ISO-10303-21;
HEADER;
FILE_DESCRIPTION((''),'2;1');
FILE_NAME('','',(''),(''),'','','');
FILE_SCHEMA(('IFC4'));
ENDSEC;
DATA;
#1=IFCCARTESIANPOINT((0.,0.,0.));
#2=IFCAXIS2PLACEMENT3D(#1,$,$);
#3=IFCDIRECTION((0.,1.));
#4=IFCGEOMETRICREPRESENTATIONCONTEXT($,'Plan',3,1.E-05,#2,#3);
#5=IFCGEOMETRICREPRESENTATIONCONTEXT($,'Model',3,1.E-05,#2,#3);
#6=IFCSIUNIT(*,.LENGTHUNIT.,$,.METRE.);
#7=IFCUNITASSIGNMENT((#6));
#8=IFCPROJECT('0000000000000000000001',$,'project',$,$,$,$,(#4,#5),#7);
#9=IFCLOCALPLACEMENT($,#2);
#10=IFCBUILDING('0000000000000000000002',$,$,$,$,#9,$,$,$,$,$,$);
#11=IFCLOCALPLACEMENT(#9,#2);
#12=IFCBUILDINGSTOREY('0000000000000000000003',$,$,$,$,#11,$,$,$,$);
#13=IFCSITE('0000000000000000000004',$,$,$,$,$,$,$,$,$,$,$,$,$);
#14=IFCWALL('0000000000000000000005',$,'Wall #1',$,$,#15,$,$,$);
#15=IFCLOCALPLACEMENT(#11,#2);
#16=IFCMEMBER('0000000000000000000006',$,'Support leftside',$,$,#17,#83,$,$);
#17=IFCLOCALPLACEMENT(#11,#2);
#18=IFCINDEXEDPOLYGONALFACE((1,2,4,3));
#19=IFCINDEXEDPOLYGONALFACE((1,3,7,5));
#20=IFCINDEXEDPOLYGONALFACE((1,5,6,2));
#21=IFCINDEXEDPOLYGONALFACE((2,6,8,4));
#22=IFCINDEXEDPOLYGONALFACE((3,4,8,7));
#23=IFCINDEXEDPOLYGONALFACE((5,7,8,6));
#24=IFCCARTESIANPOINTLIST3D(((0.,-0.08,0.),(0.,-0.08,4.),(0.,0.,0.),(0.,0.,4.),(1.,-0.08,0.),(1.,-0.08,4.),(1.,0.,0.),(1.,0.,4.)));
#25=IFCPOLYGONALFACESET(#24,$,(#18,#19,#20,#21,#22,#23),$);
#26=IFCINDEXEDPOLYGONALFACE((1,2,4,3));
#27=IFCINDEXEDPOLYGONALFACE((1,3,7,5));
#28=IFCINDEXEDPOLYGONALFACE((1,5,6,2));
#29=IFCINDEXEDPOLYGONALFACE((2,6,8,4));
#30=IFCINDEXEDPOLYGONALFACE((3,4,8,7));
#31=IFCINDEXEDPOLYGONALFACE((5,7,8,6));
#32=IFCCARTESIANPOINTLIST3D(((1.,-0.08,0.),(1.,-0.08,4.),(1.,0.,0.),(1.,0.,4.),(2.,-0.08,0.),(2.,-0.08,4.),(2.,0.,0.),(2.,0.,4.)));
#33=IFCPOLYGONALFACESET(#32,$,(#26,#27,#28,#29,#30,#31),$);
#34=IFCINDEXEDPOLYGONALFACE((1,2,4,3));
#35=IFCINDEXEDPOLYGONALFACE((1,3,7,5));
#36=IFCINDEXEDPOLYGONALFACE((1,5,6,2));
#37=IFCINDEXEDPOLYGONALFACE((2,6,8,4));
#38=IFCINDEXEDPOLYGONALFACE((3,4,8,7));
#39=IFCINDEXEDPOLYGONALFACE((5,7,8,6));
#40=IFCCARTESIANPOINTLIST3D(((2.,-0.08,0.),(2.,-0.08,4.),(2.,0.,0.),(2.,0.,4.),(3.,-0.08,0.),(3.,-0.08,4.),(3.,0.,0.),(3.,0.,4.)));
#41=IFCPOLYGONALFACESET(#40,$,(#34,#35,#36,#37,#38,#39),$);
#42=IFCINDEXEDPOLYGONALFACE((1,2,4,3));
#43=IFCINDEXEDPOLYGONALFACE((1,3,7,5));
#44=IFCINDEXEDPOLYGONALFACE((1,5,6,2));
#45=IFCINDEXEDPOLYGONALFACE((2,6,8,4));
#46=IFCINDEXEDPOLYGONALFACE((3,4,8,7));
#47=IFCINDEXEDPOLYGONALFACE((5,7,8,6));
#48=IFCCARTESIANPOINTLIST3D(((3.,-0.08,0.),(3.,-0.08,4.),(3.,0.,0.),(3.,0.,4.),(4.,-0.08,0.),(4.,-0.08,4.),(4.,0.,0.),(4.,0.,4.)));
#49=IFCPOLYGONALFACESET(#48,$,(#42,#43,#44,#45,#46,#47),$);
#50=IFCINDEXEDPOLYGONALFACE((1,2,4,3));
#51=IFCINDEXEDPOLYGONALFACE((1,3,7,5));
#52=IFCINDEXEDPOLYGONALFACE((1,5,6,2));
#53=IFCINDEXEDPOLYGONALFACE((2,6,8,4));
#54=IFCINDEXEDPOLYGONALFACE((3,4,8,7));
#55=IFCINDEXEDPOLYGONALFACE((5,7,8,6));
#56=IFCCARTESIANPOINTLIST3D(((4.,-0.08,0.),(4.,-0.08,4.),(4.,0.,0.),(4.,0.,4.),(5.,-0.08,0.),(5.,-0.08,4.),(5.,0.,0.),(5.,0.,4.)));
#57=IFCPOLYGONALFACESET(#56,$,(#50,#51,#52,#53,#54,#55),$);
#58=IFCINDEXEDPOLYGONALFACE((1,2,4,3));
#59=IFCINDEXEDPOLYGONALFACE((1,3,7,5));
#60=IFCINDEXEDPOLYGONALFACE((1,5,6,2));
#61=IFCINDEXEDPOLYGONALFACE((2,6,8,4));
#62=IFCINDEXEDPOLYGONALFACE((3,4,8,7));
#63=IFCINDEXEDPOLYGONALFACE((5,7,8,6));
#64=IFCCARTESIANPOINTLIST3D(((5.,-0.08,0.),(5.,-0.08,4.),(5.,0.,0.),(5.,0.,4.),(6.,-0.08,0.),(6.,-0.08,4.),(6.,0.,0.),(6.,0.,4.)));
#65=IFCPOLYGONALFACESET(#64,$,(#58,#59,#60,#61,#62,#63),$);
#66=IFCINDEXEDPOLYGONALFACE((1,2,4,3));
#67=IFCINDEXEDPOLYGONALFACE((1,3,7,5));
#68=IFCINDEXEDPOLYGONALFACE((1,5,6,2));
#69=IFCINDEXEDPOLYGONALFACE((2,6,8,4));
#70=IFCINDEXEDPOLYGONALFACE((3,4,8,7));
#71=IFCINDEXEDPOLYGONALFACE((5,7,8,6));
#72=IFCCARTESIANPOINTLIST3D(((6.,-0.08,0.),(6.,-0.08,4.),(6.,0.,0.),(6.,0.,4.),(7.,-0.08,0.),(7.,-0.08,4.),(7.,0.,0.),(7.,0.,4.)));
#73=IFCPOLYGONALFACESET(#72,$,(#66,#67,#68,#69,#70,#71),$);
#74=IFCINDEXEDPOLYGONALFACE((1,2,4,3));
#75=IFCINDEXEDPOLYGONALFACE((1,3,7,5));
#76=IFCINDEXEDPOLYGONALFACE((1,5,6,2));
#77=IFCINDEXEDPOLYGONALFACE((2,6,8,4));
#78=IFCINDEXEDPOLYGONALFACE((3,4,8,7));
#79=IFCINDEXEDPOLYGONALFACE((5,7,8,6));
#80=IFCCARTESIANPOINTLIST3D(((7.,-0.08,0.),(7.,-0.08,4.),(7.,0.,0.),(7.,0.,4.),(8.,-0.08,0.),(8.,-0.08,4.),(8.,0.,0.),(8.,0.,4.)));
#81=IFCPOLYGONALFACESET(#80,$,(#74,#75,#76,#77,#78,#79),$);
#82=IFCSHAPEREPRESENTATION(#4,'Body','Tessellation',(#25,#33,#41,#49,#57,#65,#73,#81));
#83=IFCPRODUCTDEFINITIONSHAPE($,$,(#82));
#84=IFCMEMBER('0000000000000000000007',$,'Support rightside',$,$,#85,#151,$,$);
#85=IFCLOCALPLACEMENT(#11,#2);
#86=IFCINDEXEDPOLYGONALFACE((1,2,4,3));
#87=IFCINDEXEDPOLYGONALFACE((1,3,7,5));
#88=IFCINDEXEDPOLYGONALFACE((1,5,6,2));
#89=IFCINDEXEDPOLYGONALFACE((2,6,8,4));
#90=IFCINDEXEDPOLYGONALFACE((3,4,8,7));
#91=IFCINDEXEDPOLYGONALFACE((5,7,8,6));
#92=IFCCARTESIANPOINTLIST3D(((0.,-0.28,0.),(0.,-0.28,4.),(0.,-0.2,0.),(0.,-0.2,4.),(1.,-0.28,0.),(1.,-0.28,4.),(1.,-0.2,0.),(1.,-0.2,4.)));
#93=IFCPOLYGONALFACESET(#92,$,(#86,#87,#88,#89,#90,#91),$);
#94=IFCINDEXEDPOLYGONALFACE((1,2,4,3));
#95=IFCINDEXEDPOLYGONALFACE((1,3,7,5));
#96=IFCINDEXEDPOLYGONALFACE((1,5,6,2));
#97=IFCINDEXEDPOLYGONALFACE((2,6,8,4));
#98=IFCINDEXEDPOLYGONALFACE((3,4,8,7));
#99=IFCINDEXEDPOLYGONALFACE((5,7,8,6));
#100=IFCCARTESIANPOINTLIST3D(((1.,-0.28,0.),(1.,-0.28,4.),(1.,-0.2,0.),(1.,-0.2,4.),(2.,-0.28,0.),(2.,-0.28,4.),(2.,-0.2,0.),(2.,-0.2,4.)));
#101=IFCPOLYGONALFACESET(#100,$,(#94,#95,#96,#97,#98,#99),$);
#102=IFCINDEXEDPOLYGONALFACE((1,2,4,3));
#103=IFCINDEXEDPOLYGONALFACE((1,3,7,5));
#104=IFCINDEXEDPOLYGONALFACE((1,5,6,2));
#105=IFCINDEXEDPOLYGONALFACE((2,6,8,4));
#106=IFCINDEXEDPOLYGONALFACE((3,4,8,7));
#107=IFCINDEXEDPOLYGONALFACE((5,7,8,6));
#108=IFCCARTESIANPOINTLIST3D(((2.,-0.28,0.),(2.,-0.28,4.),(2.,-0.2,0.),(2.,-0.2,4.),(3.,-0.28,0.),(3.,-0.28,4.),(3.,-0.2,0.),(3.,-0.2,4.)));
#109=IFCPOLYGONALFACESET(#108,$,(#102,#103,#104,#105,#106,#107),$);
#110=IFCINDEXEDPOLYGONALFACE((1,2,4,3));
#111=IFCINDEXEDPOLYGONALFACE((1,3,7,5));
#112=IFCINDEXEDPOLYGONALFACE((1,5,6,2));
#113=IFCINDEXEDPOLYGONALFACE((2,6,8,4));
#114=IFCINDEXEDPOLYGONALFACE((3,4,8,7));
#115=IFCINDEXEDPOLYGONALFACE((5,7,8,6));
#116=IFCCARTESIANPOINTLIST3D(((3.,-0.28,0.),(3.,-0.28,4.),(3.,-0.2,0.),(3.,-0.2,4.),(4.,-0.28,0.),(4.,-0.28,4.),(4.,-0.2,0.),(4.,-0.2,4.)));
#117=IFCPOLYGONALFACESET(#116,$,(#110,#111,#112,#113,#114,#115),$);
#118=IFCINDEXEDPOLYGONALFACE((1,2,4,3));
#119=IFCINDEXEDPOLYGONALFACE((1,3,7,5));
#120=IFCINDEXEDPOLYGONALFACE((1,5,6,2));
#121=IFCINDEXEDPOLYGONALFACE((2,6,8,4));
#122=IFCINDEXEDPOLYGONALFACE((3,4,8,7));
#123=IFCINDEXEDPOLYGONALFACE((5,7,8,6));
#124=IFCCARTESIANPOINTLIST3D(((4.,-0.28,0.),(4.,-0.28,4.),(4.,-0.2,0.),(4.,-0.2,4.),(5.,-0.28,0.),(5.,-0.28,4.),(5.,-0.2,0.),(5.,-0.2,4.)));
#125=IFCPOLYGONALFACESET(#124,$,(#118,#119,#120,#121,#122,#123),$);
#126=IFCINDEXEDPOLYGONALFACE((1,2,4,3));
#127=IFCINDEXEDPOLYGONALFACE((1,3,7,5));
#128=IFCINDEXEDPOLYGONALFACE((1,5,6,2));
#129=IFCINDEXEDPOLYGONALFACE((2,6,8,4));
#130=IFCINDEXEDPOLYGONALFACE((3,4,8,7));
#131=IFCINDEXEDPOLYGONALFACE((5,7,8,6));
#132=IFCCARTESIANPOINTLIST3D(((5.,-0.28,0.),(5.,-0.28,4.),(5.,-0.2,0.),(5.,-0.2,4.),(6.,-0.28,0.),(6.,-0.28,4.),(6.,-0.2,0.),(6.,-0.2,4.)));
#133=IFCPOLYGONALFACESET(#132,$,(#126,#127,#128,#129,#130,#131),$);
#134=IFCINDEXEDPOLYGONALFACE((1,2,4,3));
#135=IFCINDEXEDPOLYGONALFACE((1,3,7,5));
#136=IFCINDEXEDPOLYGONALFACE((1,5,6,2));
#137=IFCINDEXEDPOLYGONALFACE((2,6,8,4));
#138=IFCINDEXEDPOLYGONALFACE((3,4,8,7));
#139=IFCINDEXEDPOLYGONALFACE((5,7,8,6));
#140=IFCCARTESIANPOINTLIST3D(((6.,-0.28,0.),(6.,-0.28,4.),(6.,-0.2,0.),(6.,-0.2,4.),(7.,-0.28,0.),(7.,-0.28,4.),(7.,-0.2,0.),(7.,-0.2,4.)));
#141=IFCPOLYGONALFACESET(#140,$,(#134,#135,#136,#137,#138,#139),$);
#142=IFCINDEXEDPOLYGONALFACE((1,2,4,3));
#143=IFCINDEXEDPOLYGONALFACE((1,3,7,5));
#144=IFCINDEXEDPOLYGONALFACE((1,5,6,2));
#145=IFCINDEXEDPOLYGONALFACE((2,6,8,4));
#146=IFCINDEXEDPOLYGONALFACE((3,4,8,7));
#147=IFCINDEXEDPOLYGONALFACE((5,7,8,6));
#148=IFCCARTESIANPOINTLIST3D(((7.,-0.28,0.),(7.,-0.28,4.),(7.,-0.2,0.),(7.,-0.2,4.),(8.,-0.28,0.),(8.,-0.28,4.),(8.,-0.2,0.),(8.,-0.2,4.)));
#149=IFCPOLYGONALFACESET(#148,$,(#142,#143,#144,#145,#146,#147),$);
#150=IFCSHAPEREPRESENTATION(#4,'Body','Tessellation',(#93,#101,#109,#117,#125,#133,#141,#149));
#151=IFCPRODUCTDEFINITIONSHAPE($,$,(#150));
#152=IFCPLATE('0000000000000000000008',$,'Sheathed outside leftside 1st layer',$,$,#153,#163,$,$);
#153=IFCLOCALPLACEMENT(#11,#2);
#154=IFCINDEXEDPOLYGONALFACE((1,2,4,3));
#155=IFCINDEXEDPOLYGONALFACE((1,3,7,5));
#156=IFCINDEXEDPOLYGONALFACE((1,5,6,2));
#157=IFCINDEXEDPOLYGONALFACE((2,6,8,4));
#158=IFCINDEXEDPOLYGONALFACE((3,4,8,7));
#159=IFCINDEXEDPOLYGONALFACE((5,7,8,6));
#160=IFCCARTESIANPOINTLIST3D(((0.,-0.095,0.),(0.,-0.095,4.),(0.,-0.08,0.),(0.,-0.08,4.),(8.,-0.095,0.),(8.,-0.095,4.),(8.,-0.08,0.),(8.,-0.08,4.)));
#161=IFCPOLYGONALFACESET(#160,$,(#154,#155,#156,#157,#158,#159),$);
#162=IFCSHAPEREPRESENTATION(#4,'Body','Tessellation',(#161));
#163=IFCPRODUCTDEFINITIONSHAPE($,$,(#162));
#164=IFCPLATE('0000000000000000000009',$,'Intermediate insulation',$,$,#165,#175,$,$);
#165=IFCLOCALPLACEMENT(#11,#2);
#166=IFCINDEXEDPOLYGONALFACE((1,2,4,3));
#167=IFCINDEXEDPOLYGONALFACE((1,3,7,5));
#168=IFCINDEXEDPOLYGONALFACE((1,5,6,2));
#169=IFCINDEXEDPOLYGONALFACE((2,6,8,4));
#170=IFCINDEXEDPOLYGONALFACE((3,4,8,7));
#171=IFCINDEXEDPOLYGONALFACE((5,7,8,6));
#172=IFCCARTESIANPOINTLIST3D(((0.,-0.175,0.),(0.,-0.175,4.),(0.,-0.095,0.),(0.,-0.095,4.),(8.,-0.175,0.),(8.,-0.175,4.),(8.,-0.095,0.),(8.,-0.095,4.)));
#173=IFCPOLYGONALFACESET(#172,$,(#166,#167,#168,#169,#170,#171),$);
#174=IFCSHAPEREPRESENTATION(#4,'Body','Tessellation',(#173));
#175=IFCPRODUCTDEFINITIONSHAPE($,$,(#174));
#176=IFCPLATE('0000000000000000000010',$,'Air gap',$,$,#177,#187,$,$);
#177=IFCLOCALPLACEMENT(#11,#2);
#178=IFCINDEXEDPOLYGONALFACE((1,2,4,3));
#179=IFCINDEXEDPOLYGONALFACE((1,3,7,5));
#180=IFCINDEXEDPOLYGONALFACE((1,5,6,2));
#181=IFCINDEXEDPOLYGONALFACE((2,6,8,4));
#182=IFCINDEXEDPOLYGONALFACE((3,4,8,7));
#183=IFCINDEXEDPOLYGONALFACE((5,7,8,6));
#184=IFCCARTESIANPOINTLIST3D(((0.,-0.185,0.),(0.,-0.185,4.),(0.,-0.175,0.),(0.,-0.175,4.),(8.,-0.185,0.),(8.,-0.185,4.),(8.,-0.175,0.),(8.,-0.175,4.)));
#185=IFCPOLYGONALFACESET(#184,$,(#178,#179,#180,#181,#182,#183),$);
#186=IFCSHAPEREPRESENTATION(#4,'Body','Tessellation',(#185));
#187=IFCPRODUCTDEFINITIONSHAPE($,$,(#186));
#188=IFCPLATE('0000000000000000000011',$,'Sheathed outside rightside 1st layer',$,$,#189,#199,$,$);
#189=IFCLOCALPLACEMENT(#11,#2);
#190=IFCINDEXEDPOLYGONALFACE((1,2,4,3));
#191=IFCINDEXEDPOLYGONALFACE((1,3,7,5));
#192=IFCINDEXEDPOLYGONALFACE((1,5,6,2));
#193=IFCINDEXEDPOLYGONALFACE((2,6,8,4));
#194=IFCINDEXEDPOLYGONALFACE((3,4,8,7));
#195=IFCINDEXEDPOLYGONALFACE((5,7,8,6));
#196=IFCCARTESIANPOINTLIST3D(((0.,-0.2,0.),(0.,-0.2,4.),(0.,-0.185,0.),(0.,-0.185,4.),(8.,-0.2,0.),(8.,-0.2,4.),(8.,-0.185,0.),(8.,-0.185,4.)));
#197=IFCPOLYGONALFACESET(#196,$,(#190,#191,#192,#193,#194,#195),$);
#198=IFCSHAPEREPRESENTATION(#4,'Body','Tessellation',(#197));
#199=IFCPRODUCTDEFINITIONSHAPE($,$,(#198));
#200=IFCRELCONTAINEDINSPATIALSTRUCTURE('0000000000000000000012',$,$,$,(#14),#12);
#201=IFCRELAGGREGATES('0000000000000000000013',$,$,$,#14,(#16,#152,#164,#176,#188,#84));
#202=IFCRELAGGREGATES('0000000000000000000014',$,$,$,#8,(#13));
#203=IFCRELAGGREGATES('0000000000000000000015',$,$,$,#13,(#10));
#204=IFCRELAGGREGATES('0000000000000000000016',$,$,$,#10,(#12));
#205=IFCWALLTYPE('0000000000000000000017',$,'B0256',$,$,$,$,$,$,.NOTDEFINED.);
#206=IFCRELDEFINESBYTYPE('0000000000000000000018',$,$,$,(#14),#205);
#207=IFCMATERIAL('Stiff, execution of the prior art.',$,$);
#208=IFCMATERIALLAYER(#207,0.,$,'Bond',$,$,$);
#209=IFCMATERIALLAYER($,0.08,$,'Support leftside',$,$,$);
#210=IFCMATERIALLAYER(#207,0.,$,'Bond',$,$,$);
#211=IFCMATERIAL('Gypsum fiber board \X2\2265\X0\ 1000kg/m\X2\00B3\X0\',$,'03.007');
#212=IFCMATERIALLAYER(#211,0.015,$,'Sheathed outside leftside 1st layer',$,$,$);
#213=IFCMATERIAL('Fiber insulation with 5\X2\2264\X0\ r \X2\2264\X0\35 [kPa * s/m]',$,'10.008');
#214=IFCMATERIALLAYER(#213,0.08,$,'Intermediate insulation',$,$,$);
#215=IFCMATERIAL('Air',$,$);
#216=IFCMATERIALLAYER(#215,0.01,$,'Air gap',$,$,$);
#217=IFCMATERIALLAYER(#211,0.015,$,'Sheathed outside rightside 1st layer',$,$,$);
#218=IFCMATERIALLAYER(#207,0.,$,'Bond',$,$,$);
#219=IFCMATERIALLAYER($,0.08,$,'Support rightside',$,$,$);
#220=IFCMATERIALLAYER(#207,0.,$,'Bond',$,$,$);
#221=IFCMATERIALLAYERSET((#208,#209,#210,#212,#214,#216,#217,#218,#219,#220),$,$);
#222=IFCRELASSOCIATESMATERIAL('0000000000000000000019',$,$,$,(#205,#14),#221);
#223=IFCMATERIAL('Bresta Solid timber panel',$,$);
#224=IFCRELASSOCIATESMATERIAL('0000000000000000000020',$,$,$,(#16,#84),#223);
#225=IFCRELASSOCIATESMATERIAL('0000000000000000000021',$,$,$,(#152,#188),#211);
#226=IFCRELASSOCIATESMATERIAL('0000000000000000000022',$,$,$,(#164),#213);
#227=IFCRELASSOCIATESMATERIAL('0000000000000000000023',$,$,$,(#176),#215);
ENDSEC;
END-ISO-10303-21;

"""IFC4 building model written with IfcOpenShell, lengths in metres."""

from ifc_helpers import new_model, si_unit, direction, frame, frame_2d, origin, place, context, project, spatial, rectangle, extrude, material, layer, layer_set, type_object, element, aggregate, save


model = new_model("IFC4")

# Units and contexts
plan_context = context("Plan", 3, precision=1e-05, world=origin(), true_north=direction((0.0, 1.0)))
model_context = context("Model", 3, precision=1e-05, world=origin(), true_north=direction((0.0, 1.0)))
ifc_project = project(units=[si_unit("LENGTHUNIT", "METRE")], contexts=[plan_context, model_context])

# Site, building, storey
site = spatial("IfcSite", under=ifc_project)
building_placement = place(None, origin())
building = spatial("IfcBuilding", under=site, at=building_placement)
storey_placement = place(building_placement, origin())
storey = spatial("IfcBuildingStorey", under=building, at=storey_placement)

# Wall, members, plates
ifc_material_1 = material(Name="Stiff, execution of the prior art.")
ifc_layer_1 = layer(ifc_material_1, 0.0, Name="Bond")
ifc_layer_2 = layer(None, 0.08, Name="Support leftside")
ifc_layer_3 = layer(ifc_material_1, 0.0, Name="Bond")
ifc_material_2 = material(Name="Gypsum fiber board ≥ 1000kg/m³", Category="03.007")
ifc_layer_4 = layer(ifc_material_2, 0.015, Name="Sheathed outside leftside 1st layer")
ifc_material_3 = material(Name="Fiber insulation with 5≤ r ≤35 [kPa * s/m]", Category="10.008")
ifc_layer_5 = layer(ifc_material_3, 0.08, Name="Intermediate insulation")
ifc_material_4 = material(Name="Air")
ifc_layer_6 = layer(ifc_material_4, 0.01, Name="Air gap")
ifc_layer_7 = layer(ifc_material_2, 0.015, Name="Sheathed outside rightside 1st layer")
ifc_layer_8 = layer(ifc_material_1, 0.0, Name="Bond")
ifc_layer_9 = layer(None, 0.08, Name="Support rightside")
ifc_layer_10 = layer(ifc_material_1, 0.0, Name="Bond")
ifc_layer_set = layer_set([ifc_layer_1, ifc_layer_2, ifc_layer_3, ifc_layer_4, ifc_layer_5, ifc_layer_6, ifc_layer_7, ifc_layer_8, ifc_layer_9, ifc_layer_10])
wall_type = type_object("IfcWallType", Name="B0256", PredefinedType="NOTDEFINED", material=ifc_layer_set)
wall_placement = place(None, frame((0.0, 0.0, 0.0), z_axis=(0.0, -1.0, 0.0), x_axis=(1.0, 0.0, 0.0)))
wall = element("IfcWall", 1, at=wall_placement, inside=storey, type_object=wall_type, material=ifc_layer_set, Name="Wall #1")
ifc_material_5 = material(Name="Bresta Solid timber panel")
member_1_placement = place(wall_placement, origin())
member_1 = element("IfcMember", 2, at=member_1_placement, material=ifc_material_5, Name="Support leftside", context=plan_context, shape_type="SweptSolid", body=[
    extrude(rectangle(XDim=1.0, YDim=0.08, at=frame_2d((0.5, 0.04), x_axis=(1.0, 0.0))), frame((0.0, 4.0, 0.0), z_axis=(0.0, -1.0, 0.0), x_axis=(1.0, 0.0, 0.0)), (0.0, 0.0, 1.0), 4.0),
    extrude(rectangle(XDim=1.0, YDim=0.08, at=frame_2d((0.5, 0.04), x_axis=(1.0, 0.0))), frame((1.0, 4.0, 0.0), z_axis=(0.0, -1.0, 0.0), x_axis=(1.0, 0.0, 0.0)), (0.0, 0.0, 1.0), 4.0),
    extrude(rectangle(XDim=1.0, YDim=0.08, at=frame_2d((0.5, 0.04), x_axis=(1.0, 0.0))), frame((2.0, 4.0, 0.0), z_axis=(0.0, -1.0, 0.0), x_axis=(1.0, 0.0, 0.0)), (0.0, 0.0, 1.0), 4.0),
    extrude(rectangle(XDim=1.0, YDim=0.08, at=frame_2d((0.5, 0.04), x_axis=(1.0, 0.0))), frame((3.0, 4.0, 0.0), z_axis=(0.0, -1.0, 0.0), x_axis=(1.0, 0.0, 0.0)), (0.0, 0.0, 1.0), 4.0),
    extrude(rectangle(XDim=1.0, YDim=0.08, at=frame_2d((0.5, 0.04), x_axis=(1.0, 0.0))), frame((4.0, 4.0, 0.0), z_axis=(0.0, -1.0, 0.0), x_axis=(1.0, 0.0, 0.0)), (0.0, 0.0, 1.0), 4.0),
    extrude(rectangle(XDim=1.0, YDim=0.08, at=frame_2d((0.5, 0.04), x_axis=(1.0, 0.0))), frame((5.0, 4.0, 0.0), z_axis=(0.0, -1.0, 0.0), x_axis=(1.0, 0.0, 0.0)), (0.0, 0.0, 1.0), 4.0),
    extrude(rectangle(XDim=1.0, YDim=0.08, at=frame_2d((0.5, 0.04), x_axis=(1.0, 0.0))), frame((6.0, 4.0, 0.0), z_axis=(0.0, -1.0, 0.0), x_axis=(1.0, 0.0, 0.0)), (0.0, 0.0, 1.0), 4.0),
    extrude(rectangle(XDim=1.0, YDim=0.08, at=frame_2d((0.5, 0.04), x_axis=(1.0, 0.0))), frame((7.0, 4.0, 0.0), z_axis=(0.0, -1.0, 0.0), x_axis=(1.0, 0.0, 0.0)), (0.0, 0.0, 1.0), 4.0),
])
member_2_placement = place(wall_placement, origin())
member_2 = element("IfcMember", 3, at=member_2_placement, material=ifc_material_5, Name="Support rightside", context=plan_context, shape_type="SweptSolid", body=[
    extrude(rectangle(XDim=1.0, YDim=0.08, at=frame_2d((0.5, 0.04), x_axis=(1.0, 0.0))), frame((0.0, 4.0, 0.2), z_axis=(0.0, -1.0, 0.0), x_axis=(1.0, 0.0, 0.0)), (0.0, 0.0, 1.0), 4.0),
    extrude(rectangle(XDim=1.0, YDim=0.08, at=frame_2d((0.5, 0.04), x_axis=(1.0, 0.0))), frame((1.0, 4.0, 0.2), z_axis=(0.0, -1.0, 0.0), x_axis=(1.0, 0.0, 0.0)), (0.0, 0.0, 1.0), 4.0),
    extrude(rectangle(XDim=1.0, YDim=0.08, at=frame_2d((0.5, 0.04), x_axis=(1.0, 0.0))), frame((2.0, 4.0, 0.2), z_axis=(0.0, -1.0, 0.0), x_axis=(1.0, 0.0, 0.0)), (0.0, 0.0, 1.0), 4.0),
    extrude(rectangle(XDim=1.0, YDim=0.08, at=frame_2d((0.5, 0.04), x_axis=(1.0, 0.0))), frame((3.0, 4.0, 0.2), z_axis=(0.0, -1.0, 0.0), x_axis=(1.0, 0.0, 0.0)), (0.0, 0.0, 1.0), 4.0),
    extrude(rectangle(XDim=1.0, YDim=0.08, at=frame_2d((0.5, 0.04), x_axis=(1.0, 0.0))), frame((4.0, 4.0, 0.2), z_axis=(0.0, -1.0, 0.0), x_axis=(1.0, 0.0, 0.0)), (0.0, 0.0, 1.0), 4.0),
    extrude(rectangle(XDim=1.0, YDim=0.08, at=frame_2d((0.5, 0.04), x_axis=(1.0, 0.0))), frame((5.0, 4.0, 0.2), z_axis=(0.0, -1.0, 0.0), x_axis=(1.0, 0.0, 0.0)), (0.0, 0.0, 1.0), 4.0),
    extrude(rectangle(XDim=1.0, YDim=0.08, at=frame_2d((0.5, 0.04), x_axis=(1.0, 0.0))), frame((6.0, 4.0, 0.2), z_axis=(0.0, -1.0, 0.0), x_axis=(1.0, 0.0, 0.0)), (0.0, 0.0, 1.0), 4.0),
    extrude(rectangle(XDim=1.0, YDim=0.08, at=frame_2d((0.5, 0.04), x_axis=(1.0, 0.0))), frame((7.0, 4.0, 0.2), z_axis=(0.0, -1.0, 0.0), x_axis=(1.0, 0.0, 0.0)), (0.0, 0.0, 1.0), 4.0),
])
plate_1_placement = place(wall_placement, origin())
plate_1 = element("IfcPlate", 4, at=plate_1_placement, material=ifc_material_2, Name="Sheathed outside leftside 1st layer", context=plan_context, shape_type="SweptSolid", body=[
    extrude(rectangle(XDim=8.0, YDim=4.0, at=frame_2d((4.0, 2.0), x_axis=(1.0, 0.0))), frame((0.0, 0.0, 0.08), z_axis=(0.0, 0.0, 1.0), x_axis=(1.0, 0.0, 0.0)), (0.0, 0.0, 1.0), 0.015),
])
plate_2_placement = place(wall_placement, origin())
plate_2 = element("IfcPlate", 5, at=plate_2_placement, material=ifc_material_3, Name="Intermediate insulation", context=plan_context, shape_type="SweptSolid", body=[
    extrude(rectangle(XDim=8.0, YDim=4.0, at=frame_2d((4.0, 2.0), x_axis=(1.0, 0.0))), frame((0.0, 0.0, 0.095), z_axis=(0.0, 0.0, 1.0), x_axis=(1.0, 0.0, 0.0)), (0.0, 0.0, 1.0), 0.08),
])
plate_3_placement = place(wall_placement, origin())
plate_3 = element("IfcPlate", 6, at=plate_3_placement, material=ifc_material_4, Name="Air gap", context=plan_context, shape_type="SweptSolid", body=[
    extrude(rectangle(XDim=8.0, YDim=4.0, at=frame_2d((4.0, 2.0), x_axis=(1.0, 0.0))), frame((0.0, 0.0, 0.175), z_axis=(0.0, 0.0, 1.0), x_axis=(1.0, 0.0, 0.0)), (0.0, 0.0, 1.0), 0.01),
])
plate_4_placement = place(wall_placement, origin())
plate_4 = element("IfcPlate", 7, at=plate_4_placement, material=ifc_material_2, Name="Sheathed outside rightside 1st layer", context=plan_context, shape_type="SweptSolid", body=[
    extrude(rectangle(XDim=8.0, YDim=4.0, at=frame_2d((4.0, 2.0), x_axis=(1.0, 0.0))), frame((0.0, 0.0, 0.185), z_axis=(0.0, 0.0, 1.0), x_axis=(1.0, 0.0, 0.0)), (0.0, 0.0, 1.0), 0.015),
])
aggregate(wall, [member_1, plate_1, plate_2, plate_3, plate_4, member_2])

save(model, "model.ifc")
